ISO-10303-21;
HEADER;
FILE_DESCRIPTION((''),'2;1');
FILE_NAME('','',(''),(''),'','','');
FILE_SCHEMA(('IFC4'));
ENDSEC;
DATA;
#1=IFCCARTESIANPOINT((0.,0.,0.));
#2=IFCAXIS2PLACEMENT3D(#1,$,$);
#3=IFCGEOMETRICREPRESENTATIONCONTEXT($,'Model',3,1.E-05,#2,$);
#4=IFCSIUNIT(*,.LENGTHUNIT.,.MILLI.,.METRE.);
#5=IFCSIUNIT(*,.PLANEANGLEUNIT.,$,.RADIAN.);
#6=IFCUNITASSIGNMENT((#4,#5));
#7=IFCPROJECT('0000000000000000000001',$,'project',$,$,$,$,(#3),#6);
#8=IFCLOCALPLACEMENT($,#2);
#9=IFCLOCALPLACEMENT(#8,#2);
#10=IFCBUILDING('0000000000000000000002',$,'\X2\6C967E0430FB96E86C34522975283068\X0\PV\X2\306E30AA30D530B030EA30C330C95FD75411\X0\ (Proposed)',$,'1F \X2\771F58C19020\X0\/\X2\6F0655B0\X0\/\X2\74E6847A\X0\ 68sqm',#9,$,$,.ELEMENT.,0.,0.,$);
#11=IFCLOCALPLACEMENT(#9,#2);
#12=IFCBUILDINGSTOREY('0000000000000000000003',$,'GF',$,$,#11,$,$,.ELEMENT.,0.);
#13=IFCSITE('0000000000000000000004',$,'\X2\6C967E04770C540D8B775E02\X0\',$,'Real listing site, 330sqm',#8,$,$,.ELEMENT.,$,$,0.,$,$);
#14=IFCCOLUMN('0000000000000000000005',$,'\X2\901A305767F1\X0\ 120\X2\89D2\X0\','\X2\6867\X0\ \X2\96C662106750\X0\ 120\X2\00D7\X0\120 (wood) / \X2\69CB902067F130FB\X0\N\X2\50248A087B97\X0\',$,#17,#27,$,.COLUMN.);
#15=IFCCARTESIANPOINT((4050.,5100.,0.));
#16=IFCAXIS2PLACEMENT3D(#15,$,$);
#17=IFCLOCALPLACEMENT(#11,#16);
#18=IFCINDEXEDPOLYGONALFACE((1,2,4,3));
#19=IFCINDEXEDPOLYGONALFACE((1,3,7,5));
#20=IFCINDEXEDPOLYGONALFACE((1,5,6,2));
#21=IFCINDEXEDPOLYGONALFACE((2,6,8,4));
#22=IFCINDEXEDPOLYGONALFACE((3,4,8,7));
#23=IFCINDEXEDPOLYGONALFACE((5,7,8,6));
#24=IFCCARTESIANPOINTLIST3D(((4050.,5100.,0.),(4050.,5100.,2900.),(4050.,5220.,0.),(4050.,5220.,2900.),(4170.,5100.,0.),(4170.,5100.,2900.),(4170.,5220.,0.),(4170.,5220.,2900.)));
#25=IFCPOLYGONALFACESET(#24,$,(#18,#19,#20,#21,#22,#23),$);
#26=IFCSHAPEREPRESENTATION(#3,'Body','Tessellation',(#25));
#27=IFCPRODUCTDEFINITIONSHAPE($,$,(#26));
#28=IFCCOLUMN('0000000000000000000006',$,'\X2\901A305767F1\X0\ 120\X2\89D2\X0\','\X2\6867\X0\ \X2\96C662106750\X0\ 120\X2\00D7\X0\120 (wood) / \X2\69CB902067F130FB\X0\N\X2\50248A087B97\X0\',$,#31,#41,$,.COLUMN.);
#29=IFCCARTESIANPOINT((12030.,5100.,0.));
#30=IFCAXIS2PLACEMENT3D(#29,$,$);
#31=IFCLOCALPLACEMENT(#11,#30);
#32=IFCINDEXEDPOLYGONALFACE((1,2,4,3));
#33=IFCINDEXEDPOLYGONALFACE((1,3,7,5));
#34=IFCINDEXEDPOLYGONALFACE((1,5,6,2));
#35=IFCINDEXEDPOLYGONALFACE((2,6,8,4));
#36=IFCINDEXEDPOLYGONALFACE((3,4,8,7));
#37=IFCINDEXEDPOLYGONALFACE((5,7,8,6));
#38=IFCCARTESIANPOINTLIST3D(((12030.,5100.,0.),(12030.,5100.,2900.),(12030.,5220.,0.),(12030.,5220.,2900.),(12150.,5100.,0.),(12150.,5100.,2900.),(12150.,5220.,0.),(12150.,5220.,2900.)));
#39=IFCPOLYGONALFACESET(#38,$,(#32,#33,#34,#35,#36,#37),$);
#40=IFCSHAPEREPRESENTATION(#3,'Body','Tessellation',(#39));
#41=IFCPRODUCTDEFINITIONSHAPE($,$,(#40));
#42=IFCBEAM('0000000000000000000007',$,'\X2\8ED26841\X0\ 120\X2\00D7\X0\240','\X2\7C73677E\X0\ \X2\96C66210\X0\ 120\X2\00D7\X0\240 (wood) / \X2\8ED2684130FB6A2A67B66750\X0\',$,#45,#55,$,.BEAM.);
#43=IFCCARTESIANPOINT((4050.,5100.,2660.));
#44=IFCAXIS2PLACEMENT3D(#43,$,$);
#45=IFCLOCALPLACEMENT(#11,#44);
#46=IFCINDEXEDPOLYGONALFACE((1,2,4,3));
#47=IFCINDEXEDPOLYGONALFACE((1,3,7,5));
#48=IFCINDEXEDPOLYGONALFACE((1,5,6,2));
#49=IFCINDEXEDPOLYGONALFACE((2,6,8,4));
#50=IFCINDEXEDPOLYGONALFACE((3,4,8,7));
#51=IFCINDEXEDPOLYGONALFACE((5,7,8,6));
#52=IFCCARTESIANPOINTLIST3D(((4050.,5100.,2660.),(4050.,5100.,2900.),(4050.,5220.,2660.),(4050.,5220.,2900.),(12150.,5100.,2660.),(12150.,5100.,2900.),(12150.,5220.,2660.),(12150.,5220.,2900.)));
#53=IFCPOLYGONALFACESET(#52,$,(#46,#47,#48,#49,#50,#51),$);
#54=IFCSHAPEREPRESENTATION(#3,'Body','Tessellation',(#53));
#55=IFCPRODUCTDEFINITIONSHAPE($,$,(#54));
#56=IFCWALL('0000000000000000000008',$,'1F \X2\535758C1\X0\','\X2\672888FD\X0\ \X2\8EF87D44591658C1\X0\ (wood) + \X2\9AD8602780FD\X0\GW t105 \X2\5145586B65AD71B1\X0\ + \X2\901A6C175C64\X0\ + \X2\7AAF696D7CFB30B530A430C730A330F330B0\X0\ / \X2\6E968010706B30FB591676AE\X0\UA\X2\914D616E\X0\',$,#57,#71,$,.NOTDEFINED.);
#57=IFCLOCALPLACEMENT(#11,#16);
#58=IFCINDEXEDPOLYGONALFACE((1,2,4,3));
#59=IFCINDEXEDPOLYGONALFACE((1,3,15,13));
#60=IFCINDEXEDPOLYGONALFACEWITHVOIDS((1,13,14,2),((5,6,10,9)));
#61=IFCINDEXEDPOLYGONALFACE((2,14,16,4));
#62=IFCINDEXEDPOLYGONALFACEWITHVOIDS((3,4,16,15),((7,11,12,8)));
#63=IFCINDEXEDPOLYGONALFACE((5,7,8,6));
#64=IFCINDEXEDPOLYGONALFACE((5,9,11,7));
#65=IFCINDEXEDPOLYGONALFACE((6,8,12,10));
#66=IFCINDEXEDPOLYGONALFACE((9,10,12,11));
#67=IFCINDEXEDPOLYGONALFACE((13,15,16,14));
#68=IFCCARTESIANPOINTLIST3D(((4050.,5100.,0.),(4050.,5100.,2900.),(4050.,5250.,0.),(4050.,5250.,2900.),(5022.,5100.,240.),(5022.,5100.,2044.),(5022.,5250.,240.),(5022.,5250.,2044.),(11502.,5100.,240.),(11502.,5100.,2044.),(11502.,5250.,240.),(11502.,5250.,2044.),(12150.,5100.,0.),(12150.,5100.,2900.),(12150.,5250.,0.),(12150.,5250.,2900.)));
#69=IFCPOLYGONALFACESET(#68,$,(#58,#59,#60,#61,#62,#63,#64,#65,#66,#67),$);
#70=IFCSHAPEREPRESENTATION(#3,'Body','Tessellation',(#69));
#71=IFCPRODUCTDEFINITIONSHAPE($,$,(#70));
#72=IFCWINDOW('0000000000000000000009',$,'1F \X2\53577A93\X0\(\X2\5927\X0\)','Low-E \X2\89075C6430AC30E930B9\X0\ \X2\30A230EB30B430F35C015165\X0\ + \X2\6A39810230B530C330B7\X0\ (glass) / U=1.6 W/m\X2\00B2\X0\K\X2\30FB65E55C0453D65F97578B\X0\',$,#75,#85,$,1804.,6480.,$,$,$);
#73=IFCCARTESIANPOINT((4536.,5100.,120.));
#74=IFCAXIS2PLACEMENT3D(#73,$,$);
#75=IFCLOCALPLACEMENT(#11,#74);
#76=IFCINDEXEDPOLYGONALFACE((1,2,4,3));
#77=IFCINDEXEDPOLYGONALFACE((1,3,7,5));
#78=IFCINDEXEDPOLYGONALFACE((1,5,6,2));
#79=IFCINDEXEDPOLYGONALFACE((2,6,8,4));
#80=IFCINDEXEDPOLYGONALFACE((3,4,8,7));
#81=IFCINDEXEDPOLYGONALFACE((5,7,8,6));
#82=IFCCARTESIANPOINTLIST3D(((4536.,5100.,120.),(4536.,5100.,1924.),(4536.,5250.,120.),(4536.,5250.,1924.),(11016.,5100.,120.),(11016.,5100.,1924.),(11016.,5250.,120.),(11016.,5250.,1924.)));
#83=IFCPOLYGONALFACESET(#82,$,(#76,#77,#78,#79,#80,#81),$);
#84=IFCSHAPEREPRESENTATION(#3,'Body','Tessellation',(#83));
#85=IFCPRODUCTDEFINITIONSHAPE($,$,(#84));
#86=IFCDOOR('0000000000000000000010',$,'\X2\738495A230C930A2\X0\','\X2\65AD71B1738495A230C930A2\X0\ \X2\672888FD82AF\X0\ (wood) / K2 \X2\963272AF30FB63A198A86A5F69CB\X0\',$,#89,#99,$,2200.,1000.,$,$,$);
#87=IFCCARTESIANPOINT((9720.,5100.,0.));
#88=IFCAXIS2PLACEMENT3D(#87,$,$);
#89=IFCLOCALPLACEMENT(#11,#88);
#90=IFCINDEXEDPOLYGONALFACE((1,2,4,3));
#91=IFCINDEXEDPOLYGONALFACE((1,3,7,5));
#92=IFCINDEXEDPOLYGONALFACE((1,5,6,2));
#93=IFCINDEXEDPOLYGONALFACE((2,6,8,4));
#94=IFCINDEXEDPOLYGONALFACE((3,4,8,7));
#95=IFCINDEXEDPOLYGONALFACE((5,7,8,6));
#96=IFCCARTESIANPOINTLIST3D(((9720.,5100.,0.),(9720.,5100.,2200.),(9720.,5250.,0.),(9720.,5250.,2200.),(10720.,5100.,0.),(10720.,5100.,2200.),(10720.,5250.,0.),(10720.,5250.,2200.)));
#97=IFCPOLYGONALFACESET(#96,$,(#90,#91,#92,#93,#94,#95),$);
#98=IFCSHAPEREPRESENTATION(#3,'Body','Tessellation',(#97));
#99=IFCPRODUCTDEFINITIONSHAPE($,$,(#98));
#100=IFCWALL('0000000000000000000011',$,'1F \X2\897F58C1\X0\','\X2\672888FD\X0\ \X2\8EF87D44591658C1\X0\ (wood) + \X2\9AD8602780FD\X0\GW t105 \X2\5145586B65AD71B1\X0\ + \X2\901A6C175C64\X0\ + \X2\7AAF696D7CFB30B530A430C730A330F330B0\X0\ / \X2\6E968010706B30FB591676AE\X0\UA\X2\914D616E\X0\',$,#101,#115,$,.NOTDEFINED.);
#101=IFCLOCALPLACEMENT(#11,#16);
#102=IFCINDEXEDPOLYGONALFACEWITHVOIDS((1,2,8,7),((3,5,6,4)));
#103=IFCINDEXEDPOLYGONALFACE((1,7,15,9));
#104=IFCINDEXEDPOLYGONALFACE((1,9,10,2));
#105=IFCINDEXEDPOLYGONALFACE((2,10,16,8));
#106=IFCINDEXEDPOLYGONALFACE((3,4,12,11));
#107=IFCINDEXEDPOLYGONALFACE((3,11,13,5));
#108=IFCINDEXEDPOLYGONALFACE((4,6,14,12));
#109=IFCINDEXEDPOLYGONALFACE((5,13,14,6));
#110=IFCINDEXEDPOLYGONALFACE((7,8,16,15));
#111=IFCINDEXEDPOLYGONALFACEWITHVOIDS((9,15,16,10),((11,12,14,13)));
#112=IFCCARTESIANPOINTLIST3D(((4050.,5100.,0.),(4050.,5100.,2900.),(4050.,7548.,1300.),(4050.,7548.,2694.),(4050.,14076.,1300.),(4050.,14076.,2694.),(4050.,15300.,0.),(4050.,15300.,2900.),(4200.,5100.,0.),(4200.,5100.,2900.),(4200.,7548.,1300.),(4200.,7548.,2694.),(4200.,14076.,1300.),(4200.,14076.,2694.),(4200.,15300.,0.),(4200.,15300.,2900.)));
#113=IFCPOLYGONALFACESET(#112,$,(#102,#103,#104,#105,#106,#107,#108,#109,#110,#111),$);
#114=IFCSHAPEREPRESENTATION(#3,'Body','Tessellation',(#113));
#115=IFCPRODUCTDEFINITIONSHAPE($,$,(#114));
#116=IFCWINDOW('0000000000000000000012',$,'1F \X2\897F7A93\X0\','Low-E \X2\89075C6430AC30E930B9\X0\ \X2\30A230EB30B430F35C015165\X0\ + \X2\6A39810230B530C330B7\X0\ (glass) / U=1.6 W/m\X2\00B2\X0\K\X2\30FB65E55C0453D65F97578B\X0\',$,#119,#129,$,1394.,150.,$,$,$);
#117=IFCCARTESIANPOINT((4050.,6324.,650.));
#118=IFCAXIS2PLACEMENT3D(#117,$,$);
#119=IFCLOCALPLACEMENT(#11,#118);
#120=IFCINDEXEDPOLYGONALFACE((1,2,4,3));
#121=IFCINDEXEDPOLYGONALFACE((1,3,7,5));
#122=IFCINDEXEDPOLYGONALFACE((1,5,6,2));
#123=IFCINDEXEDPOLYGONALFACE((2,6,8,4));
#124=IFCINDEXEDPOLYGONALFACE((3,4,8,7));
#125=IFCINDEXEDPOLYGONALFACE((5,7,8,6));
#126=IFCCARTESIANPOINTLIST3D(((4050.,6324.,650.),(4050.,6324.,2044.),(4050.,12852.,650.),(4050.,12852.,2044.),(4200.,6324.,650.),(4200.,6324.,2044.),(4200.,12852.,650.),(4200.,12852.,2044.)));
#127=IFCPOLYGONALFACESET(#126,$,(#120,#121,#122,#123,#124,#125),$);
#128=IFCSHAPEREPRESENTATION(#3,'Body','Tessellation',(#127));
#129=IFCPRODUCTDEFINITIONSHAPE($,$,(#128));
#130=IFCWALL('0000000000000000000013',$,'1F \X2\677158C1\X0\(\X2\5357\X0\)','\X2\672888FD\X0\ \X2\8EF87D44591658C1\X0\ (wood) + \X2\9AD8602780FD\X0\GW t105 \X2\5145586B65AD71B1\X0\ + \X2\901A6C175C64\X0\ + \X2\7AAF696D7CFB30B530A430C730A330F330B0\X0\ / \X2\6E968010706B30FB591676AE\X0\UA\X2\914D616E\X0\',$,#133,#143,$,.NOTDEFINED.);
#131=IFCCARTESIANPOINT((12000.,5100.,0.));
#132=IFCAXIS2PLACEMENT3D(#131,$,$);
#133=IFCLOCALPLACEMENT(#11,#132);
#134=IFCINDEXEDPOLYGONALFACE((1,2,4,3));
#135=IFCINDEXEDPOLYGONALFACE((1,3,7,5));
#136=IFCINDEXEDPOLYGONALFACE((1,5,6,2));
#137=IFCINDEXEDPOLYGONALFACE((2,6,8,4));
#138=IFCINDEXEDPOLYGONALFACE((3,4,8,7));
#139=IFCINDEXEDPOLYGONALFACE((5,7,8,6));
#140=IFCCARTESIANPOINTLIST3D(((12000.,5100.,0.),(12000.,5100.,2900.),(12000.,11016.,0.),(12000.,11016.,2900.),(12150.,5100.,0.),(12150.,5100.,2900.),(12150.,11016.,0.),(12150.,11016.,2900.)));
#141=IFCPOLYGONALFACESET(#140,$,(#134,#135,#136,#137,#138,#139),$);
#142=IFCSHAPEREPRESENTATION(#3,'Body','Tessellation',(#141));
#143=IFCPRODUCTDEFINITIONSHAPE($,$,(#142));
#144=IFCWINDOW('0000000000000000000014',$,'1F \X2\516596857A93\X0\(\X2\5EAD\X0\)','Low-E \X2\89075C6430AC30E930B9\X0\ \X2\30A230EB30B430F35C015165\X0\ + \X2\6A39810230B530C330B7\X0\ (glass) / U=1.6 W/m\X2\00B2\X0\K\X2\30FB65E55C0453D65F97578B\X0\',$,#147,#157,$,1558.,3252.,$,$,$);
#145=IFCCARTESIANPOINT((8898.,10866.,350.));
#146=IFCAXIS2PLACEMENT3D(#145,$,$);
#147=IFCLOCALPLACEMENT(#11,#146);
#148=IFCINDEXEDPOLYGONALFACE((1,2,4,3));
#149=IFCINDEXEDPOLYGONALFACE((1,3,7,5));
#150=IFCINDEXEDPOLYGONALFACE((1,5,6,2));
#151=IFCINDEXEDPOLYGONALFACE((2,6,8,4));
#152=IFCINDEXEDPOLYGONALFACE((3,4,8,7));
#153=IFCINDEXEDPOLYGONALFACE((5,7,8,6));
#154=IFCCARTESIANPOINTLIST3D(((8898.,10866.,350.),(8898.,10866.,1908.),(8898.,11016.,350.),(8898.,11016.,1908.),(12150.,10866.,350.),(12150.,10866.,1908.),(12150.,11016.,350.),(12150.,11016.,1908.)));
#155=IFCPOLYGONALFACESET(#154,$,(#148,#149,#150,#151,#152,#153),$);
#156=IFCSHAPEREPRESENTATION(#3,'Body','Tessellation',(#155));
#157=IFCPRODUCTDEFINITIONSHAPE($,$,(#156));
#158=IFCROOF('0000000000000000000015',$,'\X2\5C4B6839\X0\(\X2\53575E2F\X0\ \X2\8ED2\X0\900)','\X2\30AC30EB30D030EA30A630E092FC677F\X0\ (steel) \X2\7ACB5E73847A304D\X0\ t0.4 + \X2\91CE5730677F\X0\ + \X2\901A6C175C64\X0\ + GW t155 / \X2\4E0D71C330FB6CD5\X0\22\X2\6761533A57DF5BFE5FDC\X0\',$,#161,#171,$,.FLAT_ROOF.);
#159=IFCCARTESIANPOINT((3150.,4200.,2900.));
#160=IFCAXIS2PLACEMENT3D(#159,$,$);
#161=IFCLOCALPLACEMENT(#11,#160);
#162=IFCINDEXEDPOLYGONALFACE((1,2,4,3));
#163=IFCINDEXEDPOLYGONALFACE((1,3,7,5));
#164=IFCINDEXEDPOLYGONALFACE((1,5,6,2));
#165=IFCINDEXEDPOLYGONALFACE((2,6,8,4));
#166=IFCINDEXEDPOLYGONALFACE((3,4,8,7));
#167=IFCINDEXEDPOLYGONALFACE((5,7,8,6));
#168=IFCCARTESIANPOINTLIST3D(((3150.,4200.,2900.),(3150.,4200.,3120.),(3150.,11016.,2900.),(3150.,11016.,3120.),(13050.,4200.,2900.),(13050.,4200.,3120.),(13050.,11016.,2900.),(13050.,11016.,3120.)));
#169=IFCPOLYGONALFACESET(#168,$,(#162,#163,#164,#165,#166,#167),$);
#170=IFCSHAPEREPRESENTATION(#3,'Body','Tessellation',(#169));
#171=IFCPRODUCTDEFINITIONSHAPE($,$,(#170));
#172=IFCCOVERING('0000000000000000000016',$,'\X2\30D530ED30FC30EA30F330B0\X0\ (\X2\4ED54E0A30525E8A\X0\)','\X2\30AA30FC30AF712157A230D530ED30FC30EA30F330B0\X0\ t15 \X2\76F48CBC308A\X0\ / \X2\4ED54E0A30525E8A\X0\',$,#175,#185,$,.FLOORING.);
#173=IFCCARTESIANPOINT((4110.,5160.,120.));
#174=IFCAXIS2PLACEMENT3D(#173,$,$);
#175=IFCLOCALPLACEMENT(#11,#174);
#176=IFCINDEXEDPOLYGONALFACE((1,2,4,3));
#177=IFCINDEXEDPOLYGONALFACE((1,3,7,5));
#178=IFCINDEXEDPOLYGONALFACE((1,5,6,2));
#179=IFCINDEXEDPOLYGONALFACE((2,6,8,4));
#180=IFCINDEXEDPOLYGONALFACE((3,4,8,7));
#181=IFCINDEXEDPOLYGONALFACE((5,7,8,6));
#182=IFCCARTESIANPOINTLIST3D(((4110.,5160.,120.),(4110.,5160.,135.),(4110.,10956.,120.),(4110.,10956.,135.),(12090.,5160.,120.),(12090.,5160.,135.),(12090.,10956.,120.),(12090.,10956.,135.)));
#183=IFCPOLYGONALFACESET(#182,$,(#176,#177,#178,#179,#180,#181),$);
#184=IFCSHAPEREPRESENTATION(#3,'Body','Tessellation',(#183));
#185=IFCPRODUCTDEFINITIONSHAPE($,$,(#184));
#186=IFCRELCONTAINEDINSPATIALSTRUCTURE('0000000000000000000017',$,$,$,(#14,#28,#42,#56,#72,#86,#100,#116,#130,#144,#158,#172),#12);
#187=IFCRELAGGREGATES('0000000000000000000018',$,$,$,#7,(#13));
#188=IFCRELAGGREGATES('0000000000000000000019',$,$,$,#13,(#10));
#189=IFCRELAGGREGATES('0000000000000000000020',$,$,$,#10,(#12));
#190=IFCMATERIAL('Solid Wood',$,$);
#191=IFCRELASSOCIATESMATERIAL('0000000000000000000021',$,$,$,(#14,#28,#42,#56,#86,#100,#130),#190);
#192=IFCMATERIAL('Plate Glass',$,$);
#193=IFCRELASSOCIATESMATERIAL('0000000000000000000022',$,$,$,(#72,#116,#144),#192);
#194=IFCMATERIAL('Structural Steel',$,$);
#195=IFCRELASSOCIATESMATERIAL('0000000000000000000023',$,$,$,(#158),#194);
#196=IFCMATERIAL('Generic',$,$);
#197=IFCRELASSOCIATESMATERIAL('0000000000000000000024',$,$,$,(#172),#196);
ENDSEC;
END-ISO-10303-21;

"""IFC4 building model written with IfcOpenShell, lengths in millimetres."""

from ifc_helpers import new_model, si_unit, frame, frame_2d, origin, place, context, project, spatial, rectangle, extrude, material, element, fill, save


model = new_model("IFC4")

# Units and contexts
model_context = context("Model", 3, precision=1e-05, world=origin())
ifc_project = project(units=[si_unit("LENGTHUNIT", "METRE", prefix="MILLI"), si_unit("PLANEANGLEUNIT", "RADIAN")], contexts=[model_context])

# Site, building, storey
site_placement = place(None, origin())
site = spatial("IfcSite", under=ifc_project, at=site_placement, Name="沖縄県名護市", ObjectType="Real listing site, 330sqm", CompositionType="ELEMENT", RefElevation=0.0)
building_placement = place(site_placement, origin())
building = spatial("IfcBuilding", under=site, at=building_placement, Name="沖縄・雨水利用とPVのオフグリッド志向 (Proposed)", ObjectType="1F 真壁造/漆喰/瓦葺 68sqm", CompositionType="ELEMENT", ElevationOfRefHeight=0.0, ElevationOfTerrain=0.0)
storey_placement = place(building_placement, origin())
storey = spatial("IfcBuildingStorey", under=building, at=storey_placement, Name="GF", CompositionType="ELEMENT", Elevation=0.0)

# Columns
ifc_material_1 = material(Name="Solid Wood")
column_1_placement = place(storey_placement, frame((4050.0, 5100.0, 0.0)))
element("IfcColumn", 1, at=column_1_placement, inside=storey, material=ifc_material_1, Name="通し柱 120角", Description="桧 集成材 120×120 (wood) / 構造柱・N値計算", PredefinedType="COLUMN", context=model_context, shape_type="SweptSolid", body=[
    extrude(rectangle(XDim=120.0, YDim=120.0, at=frame_2d((60.0, 60.0))), frame((4050.0, 5100.0, 0.0)), (0.0, 0.0, 1.0), 2900.0),
])
column_2_placement = place(storey_placement, frame((12030.0, 5100.0, 0.0)))
element("IfcColumn", 2, at=column_2_placement, inside=storey, material=ifc_material_1, Name="通し柱 120角", Description="桧 集成材 120×120 (wood) / 構造柱・N値計算", PredefinedType="COLUMN", context=model_context, shape_type="SweptSolid", body=[
    extrude(rectangle(XDim=120.0, YDim=120.0, at=frame_2d((60.0, 60.0))), frame((12030.0, 5100.0, 0.0)), (0.0, 0.0, 1.0), 2900.0),
])

# Beam
beam_1_placement = place(storey_placement, frame((4050.0, 5100.0, 2660.0)))
element("IfcBeam", 3, at=beam_1_placement, inside=storey, material=ifc_material_1, Name="軒桁 120×240", Description="米松 集成 120×240 (wood) / 軒桁・横架材", PredefinedType="BEAM", context=model_context, shape_type="SweptSolid", body=[
    extrude(rectangle(XDim=8100.0, YDim=120.0, at=frame_2d((4050.0, 60.0))), frame((4050.0, 5100.0, 2660.0)), (0.0, 0.0, 1.0), 240.0),
])

# Wall, openings, window, door
wall_1_placement = place(storey_placement, frame((4050.0, 5100.0, 0.0)))
wall_1 = element("IfcWall", 4, at=wall_1_placement, inside=storey, material=ifc_material_1, Name="1F 南壁", Description="木製 軸組外壁 (wood) + 高性能GW t105 充填断熱 + 通気層 + 窯業系サイディング / 準耐火・外皮UA配慮", PredefinedType="NOTDEFINED", context=model_context, shape_type="SweptSolid", body=[
    extrude(rectangle(XDim=8100.0, YDim=150.0, at=frame_2d((4050.0, 75.0))), frame((4050.0, 5100.0, 0.0)), (0.0, 0.0, 1.0), 2900.0),
])
opening_1_placement = place(storey_placement, frame((4536.0, 5100.0, 120.0)))
opening_1 = element("IfcOpeningElement", 5, at=opening_1_placement, cuts=wall_1, PredefinedType="NOTDEFINED", context=model_context, shape_type="SweptSolid", body=[
    extrude(rectangle(XDim=6480.0, YDim=150.0, at=frame_2d((3240.0, 75.0))), frame((4536.0, 5100.0, 120.0)), (0.0, 0.0, 1.0), 1804.0),
])
opening_2_placement = place(storey_placement, frame((9720.0, 5100.0, 0.0)))
opening_2 = element("IfcOpeningElement", 6, at=opening_2_placement, cuts=wall_1, PredefinedType="NOTDEFINED", context=model_context, shape_type="SweptSolid", body=[
    extrude(rectangle(XDim=1000.0, YDim=150.0, at=frame_2d((500.0, 75.0))), frame((9720.0, 5100.0, 0.0)), (0.0, 0.0, 1.0), 2200.0),
])
ifc_material_2 = material(Name="Plate Glass")
window_1_placement = place(storey_placement, frame((4536.0, 5100.0, 120.0)))
window_1 = element("IfcWindow", 7, at=window_1_placement, inside=storey, material=ifc_material_2, Name="1F 南窓(大)", Description="Low-E 複層ガラス アルゴン封入 + 樹脂サッシ (glass) / U=1.6 W/m²K・日射取得型", OverallHeight=1804.0, OverallWidth=6480.0, context=model_context, shape_type="SweptSolid", body=[
    extrude(rectangle(XDim=6480.0, YDim=150.0, at=frame_2d((3240.0, 75.0))), frame((4536.0, 5100.0, 120.0)), (0.0, 0.0, 1.0), 1804.0),
])
fill(opening_1, window_1)
door_1_placement = place(storey_placement, frame((9720.0, 5100.0, 0.0)))
door_1 = element("IfcDoor", 8, at=door_1_placement, inside=storey, material=ifc_material_1, Name="玄関ドア", Description="断熱玄関ドア 木製芯 (wood) / K2 防犯・採風機構", OverallHeight=2200.0, OverallWidth=1000.0, context=model_context, shape_type="SweptSolid", body=[
    extrude(rectangle(XDim=1000.0, YDim=150.0, at=frame_2d((500.0, 75.0))), frame((9720.0, 5100.0, 0.0)), (0.0, 0.0, 1.0), 2200.0),
])
fill(opening_2, door_1)

# Walls, openings, windows
wall_2_placement = place(storey_placement, frame((4050.0, 5100.0, 0.0)))
wall_2 = element("IfcWall", 9, at=wall_2_placement, inside=storey, material=ifc_material_1, Name="1F 西壁", Description="木製 軸組外壁 (wood) + 高性能GW t105 充填断熱 + 通気層 + 窯業系サイディング / 準耐火・外皮UA配慮", PredefinedType="NOTDEFINED", context=model_context, shape_type="SweptSolid", body=[
    extrude(rectangle(XDim=150.0, YDim=10200.0, at=frame_2d((75.0, 5100.0))), frame((4050.0, 5100.0, 0.0)), (0.0, 0.0, 1.0), 2900.0),
])
opening_3_placement = place(storey_placement, frame((4050.0, 6324.0, 650.0)))
opening_3 = element("IfcOpeningElement", 10, at=opening_3_placement, cuts=wall_2, PredefinedType="NOTDEFINED", context=model_context, shape_type="SweptSolid", body=[
    extrude(rectangle(XDim=150.0, YDim=6528.0, at=frame_2d((75.0, 3264.0))), frame((4050.0, 6324.0, 650.0)), (0.0, 0.0, 1.0), 1394.0),
])
window_2_placement = place(storey_placement, frame((4050.0, 6324.0, 650.0)))
window_2 = element("IfcWindow", 11, at=window_2_placement, inside=storey, material=ifc_material_2, Name="1F 西窓", Description="Low-E 複層ガラス アルゴン封入 + 樹脂サッシ (glass) / U=1.6 W/m²K・日射取得型", OverallHeight=1394.0, OverallWidth=150.0, context=model_context, shape_type="SweptSolid", body=[
    extrude(rectangle(XDim=150.0, YDim=6528.0, at=frame_2d((75.0, 3264.0))), frame((4050.0, 6324.0, 650.0)), (0.0, 0.0, 1.0), 1394.0),
])
fill(opening_3, window_2)
wall_3_placement = place(storey_placement, frame((12000.0, 5100.0, 0.0)))
wall_3 = element("IfcWall", 12, at=wall_3_placement, inside=storey, material=ifc_material_1, Name="1F 東壁(南)", Description="木製 軸組外壁 (wood) + 高性能GW t105 充填断熱 + 通気層 + 窯業系サイディング / 準耐火・外皮UA配慮", PredefinedType="NOTDEFINED", context=model_context, shape_type="SweptSolid", body=[
    extrude(rectangle(XDim=150.0, YDim=5916.0, at=frame_2d((75.0, 2958.0))), frame((12000.0, 5100.0, 0.0)), (0.0, 0.0, 1.0), 2900.0),
])
opening_4_placement = place(storey_placement, frame((8898.0, 10866.0, 350.0)))
opening_4 = element("IfcOpeningElement", 13, at=opening_4_placement, cuts=wall_3, PredefinedType="NOTDEFINED", context=model_context, shape_type="SweptSolid", body=[
    extrude(rectangle(XDim=3252.0, YDim=150.0, at=frame_2d((1626.0, 75.0))), frame((8898.0, 10866.0, 350.0)), (0.0, 0.0, 1.0), 1558.0),
])
window_3_placement = place(storey_placement, frame((8898.0, 10866.0, 350.0)))
window_3 = element("IfcWindow", 14, at=window_3_placement, inside=storey, material=ifc_material_2, Name="1F 入隅窓(庭)", Description="Low-E 複層ガラス アルゴン封入 + 樹脂サッシ (glass) / U=1.6 W/m²K・日射取得型", OverallHeight=1558.0, OverallWidth=3252.0, context=model_context, shape_type="SweptSolid", body=[
    extrude(rectangle(XDim=3252.0, YDim=150.0, at=frame_2d((1626.0, 75.0))), frame((8898.0, 10866.0, 350.0)), (0.0, 0.0, 1.0), 1558.0),
])
fill(opening_4, window_3)

# Roof
ifc_material_3 = material(Name="Structural Steel")
roof_placement = place(storey_placement, frame((3150.0, 4200.0, 2900.0)))
element("IfcRoof", 15, at=roof_placement, inside=storey, material=ifc_material_3, Name="屋根(南帯 軒900)", Description="ガルバリウム鋼板 (steel) 立平葺き t0.4 + 野地板 + 通気層 + GW t155 / 不燃・法22条区域対応", PredefinedType="FLAT_ROOF", context=model_context, shape_type="SweptSolid", body=[
    extrude(rectangle(XDim=9900.0, YDim=6816.0, at=frame_2d((4950.0, 3408.0))), frame((3150.0, 4200.0, 2900.0)), (0.0, 0.0, 1.0), 220.0),
])

# Covering
ifc_material_4 = material(Name="Generic")
covering_1_placement = place(storey_placement, frame((4110.0, 5160.0, 120.0)))
element("IfcCovering", 16, at=covering_1_placement, inside=storey, material=ifc_material_4, Name="フローリング (仕上げ床)", Description="オーク無垢フローリング t15 直貼り / 仕上げ床", PredefinedType="FLOORING", context=model_context, shape_type="SweptSolid", body=[
    extrude(rectangle(XDim=7980.0, YDim=5796.0, at=frame_2d((3990.0, 2898.0))), frame((4110.0, 5160.0, 120.0)), (0.0, 0.0, 1.0), 15.0),
])

save(model, "model.ifc")
